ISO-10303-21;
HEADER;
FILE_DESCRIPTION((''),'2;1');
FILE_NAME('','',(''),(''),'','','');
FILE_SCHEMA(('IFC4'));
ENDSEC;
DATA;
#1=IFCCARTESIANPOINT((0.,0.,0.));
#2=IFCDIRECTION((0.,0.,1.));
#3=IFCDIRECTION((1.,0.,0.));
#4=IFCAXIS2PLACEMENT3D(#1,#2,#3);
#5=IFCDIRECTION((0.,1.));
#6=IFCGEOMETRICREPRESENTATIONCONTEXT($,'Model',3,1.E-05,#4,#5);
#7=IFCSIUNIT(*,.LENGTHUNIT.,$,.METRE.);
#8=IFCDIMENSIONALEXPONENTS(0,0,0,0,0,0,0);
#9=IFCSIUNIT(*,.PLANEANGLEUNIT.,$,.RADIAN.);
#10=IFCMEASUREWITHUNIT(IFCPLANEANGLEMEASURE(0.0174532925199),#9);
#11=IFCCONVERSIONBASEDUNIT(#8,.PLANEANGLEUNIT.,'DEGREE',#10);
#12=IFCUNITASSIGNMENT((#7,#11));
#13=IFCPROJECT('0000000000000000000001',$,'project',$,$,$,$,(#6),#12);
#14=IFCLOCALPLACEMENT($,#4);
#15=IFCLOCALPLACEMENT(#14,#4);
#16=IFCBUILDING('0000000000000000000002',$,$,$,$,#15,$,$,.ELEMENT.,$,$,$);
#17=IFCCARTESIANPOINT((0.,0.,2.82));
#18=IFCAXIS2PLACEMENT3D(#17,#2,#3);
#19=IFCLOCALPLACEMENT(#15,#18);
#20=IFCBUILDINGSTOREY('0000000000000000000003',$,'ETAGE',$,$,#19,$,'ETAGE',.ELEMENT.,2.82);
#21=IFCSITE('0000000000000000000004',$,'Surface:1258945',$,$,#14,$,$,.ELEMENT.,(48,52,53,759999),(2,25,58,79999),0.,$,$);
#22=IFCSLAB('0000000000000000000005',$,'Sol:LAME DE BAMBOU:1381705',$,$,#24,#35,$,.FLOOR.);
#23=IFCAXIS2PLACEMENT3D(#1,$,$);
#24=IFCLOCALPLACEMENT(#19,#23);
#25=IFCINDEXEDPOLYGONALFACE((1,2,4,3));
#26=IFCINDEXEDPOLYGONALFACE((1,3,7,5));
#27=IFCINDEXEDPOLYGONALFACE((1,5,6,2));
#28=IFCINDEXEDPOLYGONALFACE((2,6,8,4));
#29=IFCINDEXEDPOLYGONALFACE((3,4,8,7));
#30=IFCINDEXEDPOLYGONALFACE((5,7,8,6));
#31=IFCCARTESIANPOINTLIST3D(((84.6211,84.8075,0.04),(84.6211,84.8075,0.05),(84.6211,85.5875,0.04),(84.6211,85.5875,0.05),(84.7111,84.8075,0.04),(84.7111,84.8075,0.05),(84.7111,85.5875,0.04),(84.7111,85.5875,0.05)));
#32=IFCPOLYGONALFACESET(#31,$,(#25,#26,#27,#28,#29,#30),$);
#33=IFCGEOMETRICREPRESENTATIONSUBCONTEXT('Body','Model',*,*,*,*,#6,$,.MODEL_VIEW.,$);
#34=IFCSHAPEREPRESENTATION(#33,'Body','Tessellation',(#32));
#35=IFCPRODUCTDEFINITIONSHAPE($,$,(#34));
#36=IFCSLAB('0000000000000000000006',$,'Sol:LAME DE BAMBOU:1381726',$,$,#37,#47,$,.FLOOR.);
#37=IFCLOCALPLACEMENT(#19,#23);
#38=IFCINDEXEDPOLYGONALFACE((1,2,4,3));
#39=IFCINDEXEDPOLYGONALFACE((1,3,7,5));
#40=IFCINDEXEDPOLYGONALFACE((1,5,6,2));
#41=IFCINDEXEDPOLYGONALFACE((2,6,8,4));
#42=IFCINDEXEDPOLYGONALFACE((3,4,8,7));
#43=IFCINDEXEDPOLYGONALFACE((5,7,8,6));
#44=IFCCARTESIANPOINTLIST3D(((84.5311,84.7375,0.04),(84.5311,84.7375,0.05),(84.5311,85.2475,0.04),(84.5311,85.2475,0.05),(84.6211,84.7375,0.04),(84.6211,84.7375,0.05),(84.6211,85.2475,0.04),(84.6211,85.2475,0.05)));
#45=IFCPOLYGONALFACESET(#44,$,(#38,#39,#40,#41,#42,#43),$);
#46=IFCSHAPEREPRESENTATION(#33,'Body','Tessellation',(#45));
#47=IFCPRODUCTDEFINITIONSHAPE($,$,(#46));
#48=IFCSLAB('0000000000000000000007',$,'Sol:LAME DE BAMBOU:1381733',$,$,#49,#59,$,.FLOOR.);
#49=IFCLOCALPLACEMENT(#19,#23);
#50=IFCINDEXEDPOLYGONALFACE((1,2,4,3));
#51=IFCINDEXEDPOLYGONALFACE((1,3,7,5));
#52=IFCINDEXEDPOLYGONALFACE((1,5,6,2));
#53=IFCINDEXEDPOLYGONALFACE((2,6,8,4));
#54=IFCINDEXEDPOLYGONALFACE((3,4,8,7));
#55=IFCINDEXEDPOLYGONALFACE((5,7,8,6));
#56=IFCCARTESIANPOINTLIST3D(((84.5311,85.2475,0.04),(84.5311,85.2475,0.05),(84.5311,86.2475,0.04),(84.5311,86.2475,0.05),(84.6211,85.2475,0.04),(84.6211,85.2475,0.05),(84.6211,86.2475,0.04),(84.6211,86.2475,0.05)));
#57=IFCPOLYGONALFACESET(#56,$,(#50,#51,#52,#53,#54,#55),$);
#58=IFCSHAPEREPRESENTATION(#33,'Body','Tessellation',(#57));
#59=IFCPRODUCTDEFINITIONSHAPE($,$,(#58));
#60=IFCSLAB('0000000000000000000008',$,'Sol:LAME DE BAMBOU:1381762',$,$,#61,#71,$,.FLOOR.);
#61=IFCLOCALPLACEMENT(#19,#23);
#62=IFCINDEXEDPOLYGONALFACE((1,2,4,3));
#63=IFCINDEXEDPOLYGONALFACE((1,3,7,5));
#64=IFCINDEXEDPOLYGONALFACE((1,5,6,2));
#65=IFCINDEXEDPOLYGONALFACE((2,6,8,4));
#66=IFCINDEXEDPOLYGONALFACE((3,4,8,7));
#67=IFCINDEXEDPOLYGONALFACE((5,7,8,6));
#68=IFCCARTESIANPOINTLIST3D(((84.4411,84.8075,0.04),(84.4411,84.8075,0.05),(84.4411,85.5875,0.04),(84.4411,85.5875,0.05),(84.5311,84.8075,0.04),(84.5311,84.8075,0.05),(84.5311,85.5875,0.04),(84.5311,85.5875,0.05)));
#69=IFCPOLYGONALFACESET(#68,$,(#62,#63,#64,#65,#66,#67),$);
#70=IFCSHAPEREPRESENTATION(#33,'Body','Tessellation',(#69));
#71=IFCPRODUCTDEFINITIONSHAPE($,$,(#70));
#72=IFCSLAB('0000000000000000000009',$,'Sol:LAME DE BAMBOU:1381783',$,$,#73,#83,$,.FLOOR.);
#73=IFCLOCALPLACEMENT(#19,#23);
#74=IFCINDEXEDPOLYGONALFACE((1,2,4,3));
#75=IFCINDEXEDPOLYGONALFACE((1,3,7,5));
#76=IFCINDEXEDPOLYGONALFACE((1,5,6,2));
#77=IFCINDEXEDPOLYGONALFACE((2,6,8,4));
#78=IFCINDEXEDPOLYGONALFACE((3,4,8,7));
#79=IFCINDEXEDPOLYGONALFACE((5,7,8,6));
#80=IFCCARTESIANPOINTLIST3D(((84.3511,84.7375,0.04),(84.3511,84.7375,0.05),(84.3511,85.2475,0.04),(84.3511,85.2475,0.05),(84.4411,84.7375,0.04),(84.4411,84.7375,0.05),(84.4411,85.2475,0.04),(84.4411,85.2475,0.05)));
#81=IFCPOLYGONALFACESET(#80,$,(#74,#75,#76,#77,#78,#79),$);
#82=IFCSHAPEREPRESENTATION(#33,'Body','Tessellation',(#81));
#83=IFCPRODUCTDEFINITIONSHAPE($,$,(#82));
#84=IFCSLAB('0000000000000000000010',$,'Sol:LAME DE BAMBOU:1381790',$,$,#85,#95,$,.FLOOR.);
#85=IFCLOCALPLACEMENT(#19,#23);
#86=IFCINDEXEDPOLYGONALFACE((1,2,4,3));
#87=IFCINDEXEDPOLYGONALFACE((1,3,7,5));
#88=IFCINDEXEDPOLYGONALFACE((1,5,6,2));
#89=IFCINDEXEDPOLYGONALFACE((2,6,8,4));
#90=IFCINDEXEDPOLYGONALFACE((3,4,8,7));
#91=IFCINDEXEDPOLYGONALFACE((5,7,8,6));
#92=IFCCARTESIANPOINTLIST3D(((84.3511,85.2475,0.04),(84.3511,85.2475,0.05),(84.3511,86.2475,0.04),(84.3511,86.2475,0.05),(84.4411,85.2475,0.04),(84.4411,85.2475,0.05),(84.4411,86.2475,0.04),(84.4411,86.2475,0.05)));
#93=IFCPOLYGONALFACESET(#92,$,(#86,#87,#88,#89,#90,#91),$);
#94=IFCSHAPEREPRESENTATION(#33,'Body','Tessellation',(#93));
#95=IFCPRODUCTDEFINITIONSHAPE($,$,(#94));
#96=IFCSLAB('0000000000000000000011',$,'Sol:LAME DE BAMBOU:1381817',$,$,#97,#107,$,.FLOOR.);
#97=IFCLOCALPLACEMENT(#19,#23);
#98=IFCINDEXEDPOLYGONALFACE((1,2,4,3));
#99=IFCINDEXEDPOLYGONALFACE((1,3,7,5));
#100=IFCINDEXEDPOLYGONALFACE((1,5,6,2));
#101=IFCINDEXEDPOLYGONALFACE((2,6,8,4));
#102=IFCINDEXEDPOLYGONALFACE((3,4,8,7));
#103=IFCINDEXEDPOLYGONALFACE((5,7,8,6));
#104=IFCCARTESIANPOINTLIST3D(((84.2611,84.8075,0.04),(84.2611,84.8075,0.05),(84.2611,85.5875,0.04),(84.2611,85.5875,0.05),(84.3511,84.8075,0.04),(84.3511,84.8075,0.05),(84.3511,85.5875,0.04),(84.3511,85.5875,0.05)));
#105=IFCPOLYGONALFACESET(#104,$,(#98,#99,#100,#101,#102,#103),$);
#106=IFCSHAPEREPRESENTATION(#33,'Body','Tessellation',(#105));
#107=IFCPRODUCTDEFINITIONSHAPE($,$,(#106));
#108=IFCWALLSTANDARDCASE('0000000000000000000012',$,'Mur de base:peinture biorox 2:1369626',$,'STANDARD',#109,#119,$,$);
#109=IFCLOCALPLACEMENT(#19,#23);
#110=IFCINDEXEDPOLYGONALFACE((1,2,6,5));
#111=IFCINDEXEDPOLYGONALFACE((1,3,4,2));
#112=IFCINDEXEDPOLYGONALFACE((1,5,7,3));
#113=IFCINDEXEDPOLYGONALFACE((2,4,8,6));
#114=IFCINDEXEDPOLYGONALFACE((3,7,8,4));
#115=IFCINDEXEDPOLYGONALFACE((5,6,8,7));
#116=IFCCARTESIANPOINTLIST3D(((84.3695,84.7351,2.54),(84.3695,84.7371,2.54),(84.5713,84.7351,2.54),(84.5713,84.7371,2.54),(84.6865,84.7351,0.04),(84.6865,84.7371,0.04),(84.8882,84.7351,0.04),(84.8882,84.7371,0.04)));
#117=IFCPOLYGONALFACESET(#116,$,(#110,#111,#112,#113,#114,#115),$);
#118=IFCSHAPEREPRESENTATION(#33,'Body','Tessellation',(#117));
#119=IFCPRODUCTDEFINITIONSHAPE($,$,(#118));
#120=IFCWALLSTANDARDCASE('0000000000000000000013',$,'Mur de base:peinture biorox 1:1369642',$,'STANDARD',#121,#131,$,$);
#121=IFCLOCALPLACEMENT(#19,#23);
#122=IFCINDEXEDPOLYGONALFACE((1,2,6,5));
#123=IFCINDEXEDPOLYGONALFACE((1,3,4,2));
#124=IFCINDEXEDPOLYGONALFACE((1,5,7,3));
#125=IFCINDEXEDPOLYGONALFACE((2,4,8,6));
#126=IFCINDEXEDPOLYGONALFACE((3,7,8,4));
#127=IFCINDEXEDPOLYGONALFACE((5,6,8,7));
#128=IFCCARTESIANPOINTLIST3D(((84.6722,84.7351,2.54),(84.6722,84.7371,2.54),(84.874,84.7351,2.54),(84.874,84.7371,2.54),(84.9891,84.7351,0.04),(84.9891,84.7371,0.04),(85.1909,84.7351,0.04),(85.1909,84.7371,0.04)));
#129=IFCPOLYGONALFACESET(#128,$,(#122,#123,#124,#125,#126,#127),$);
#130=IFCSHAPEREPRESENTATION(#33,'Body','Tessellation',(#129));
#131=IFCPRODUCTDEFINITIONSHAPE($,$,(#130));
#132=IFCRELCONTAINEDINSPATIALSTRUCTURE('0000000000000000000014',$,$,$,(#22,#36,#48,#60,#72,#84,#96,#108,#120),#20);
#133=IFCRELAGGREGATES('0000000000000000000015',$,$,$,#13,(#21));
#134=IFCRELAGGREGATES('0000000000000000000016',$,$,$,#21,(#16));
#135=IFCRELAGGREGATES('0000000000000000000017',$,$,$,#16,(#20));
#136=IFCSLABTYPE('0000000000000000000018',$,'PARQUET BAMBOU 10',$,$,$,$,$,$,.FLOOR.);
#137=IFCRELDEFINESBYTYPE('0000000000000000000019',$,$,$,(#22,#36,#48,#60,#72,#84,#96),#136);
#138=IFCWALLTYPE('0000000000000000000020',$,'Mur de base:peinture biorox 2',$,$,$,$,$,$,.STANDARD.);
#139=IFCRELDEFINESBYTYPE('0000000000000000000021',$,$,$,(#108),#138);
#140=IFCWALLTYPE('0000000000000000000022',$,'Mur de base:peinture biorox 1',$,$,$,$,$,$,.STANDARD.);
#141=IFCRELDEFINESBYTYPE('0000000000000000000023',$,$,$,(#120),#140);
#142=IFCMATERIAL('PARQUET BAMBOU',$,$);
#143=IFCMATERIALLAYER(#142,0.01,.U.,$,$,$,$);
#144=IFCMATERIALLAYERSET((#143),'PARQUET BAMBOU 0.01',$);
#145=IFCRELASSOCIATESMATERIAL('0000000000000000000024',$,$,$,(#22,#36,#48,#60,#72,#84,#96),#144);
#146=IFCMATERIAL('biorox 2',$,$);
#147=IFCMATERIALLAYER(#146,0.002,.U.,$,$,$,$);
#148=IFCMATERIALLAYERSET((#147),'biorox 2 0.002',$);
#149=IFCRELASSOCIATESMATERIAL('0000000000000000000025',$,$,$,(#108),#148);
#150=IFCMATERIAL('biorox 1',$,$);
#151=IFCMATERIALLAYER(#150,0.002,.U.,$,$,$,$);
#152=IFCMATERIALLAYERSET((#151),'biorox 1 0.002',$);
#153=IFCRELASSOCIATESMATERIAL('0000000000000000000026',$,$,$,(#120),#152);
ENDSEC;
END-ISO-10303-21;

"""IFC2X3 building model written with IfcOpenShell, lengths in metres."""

from ifc_helpers import new_model, entity, si_unit, converted_unit, direction, frame, origin_with_axes, place, context, subcontext, project, spatial, polyline, outline, extrude, clip, halfspace, material, layer, layer_set, layer_usage, type_object, element, save


model = new_model("IFC2X3")

# Units and contexts
model_context = context("Model", 3, precision=1e-05, world=origin_with_axes(), true_north=direction((0.0, 1.0)))
body_context = subcontext(model_context, "Body", "Model", "MODEL_VIEW")
ifc_project = project(units=[si_unit("LENGTHUNIT", "METRE"), converted_unit("PLANEANGLEUNIT", "DEGREE", entity("IfcPlaneAngleMeasure", 0.0174532925199), si_unit("PLANEANGLEUNIT", "RADIAN"), dimensions=[0, 0, 0, 0, 0, 0, 0])], contexts=[model_context])

# Site, building, storey
site_placement = place(None, origin_with_axes())
site = spatial("IfcSite", under=ifc_project, at=site_placement, Name="Surface:1258945", CompositionType="ELEMENT", RefLatitude=(48, 52, 53, 759999), RefLongitude=(2, 25, 58, 79999), RefElevation=0.0)
building_placement = place(site_placement, origin_with_axes())
building = spatial("IfcBuilding", under=site, at=building_placement, CompositionType="ELEMENT")
storey_placement = place(building_placement, frame((0.0, 0.0, 2.82), z_axis=(0.0, 0.0, 1.0), x_axis=(1.0, 0.0, 0.0)))
storey = spatial("IfcBuildingStorey", under=building, at=storey_placement, Name="ETAGE", LongName="ETAGE", CompositionType="ELEMENT", Elevation=2.82)

# Slabs
ifc_material_1 = material(Name="PARQUET BAMBOU")
ifc_layer_1 = layer(ifc_material_1, 0.01, ventilated="UNKNOWN")
ifc_layer_set_1 = layer_set([ifc_layer_1], Name="PARQUET BAMBOU 0.01")
slab_type = type_object("IfcSlabType", Name="PARQUET BAMBOU 10", PredefinedType="FLOOR")
ifc_layer_usage_1 = layer_usage(ifc_layer_set_1, "AXIS3", "NEGATIVE", 0.01)
slab_1_placement = place(storey_placement, frame((84.6211, 85.5875, 0.05), z_axis=(0.0, 0.0, 1.0), x_axis=(1.0, 0.0, 0.0)))
element("IfcSlab", 1, at=slab_1_placement, inside=storey, type_object=slab_type, material=ifc_layer_usage_1, Name="Sol:LAME DE BAMBOU:1381705", PredefinedType="FLOOR", context=body_context, shape_type="SweptSolid", body=[
    extrude(outline(polyline([(0.0, 0.0), (0.0, -0.78), (0.09, -0.78), (0.09, 0.0), (0.0, 0.0)])), frame((0.0, 0.0, -0.01), z_axis=(0.0, 0.0, 1.0), x_axis=(1.0, 0.0, 0.0)), (0.0, 0.0, 1.0), 0.01),
])
ifc_layer_usage_2 = layer_usage(ifc_layer_set_1, "AXIS3", "NEGATIVE", 0.01)
slab_2_placement = place(storey_placement, frame((84.5311, 85.2475, 0.05), z_axis=(0.0, 0.0, 1.0), x_axis=(1.0, 0.0, 0.0)))
element("IfcSlab", 2, at=slab_2_placement, inside=storey, type_object=slab_type, material=ifc_layer_usage_2, Name="Sol:LAME DE BAMBOU:1381726", PredefinedType="FLOOR", context=body_context, shape_type="SweptSolid", body=[
    extrude(outline(polyline([(0.0, 0.0), (0.0, -0.51), (0.09, -0.51), (0.09, 0.0), (0.0, 0.0)])), frame((0.0, 0.0, -0.01), z_axis=(0.0, 0.0, 1.0), x_axis=(1.0, 0.0, 0.0)), (0.0, 0.0, 1.0), 0.01),
])
ifc_layer_usage_3 = layer_usage(ifc_layer_set_1, "AXIS3", "NEGATIVE", 0.01)
slab_3_placement = place(storey_placement, frame((84.5311, 86.2475, 0.05), z_axis=(0.0, 0.0, 1.0), x_axis=(1.0, 0.0, 0.0)))
element("IfcSlab", 3, at=slab_3_placement, inside=storey, type_object=slab_type, material=ifc_layer_usage_3, Name="Sol:LAME DE BAMBOU:1381733", PredefinedType="FLOOR", context=body_context, shape_type="SweptSolid", body=[
    extrude(outline(polyline([(0.0, 0.0), (0.0, -1.0), (0.09, -1.0), (0.09, 0.0), (0.0, 0.0)])), frame((0.0, 0.0, -0.01), z_axis=(0.0, 0.0, 1.0), x_axis=(1.0, 0.0, 0.0)), (0.0, 0.0, 1.0), 0.01),
])
ifc_layer_usage_4 = layer_usage(ifc_layer_set_1, "AXIS3", "NEGATIVE", 0.01)
slab_4_placement = place(storey_placement, frame((84.4411, 85.5875, 0.05), z_axis=(0.0, 0.0, 1.0), x_axis=(1.0, 0.0, 0.0)))
element("IfcSlab", 4, at=slab_4_placement, inside=storey, type_object=slab_type, material=ifc_layer_usage_4, Name="Sol:LAME DE BAMBOU:1381762", PredefinedType="FLOOR", context=body_context, shape_type="SweptSolid", body=[
    extrude(outline(polyline([(0.0, 0.0), (0.0, -0.78), (0.09, -0.78), (0.09, 0.0), (0.0, 0.0)])), frame((0.0, 0.0, -0.01), z_axis=(0.0, 0.0, 1.0), x_axis=(1.0, 0.0, 0.0)), (0.0, 0.0, 1.0), 0.01),
])
ifc_layer_usage_5 = layer_usage(ifc_layer_set_1, "AXIS3", "NEGATIVE", 0.01)
slab_5_placement = place(storey_placement, frame((84.3511, 85.2475, 0.05), z_axis=(0.0, 0.0, 1.0), x_axis=(1.0, 0.0, 0.0)))
element("IfcSlab", 5, at=slab_5_placement, inside=storey, type_object=slab_type, material=ifc_layer_usage_5, Name="Sol:LAME DE BAMBOU:1381783", PredefinedType="FLOOR", context=body_context, shape_type="SweptSolid", body=[
    extrude(outline(polyline([(0.0, 0.0), (0.0, -0.51), (0.09, -0.51), (0.09, 0.0), (0.0, 0.0)])), frame((0.0, 0.0, -0.01), z_axis=(0.0, 0.0, 1.0), x_axis=(1.0, 0.0, 0.0)), (0.0, 0.0, 1.0), 0.01),
])
ifc_layer_usage_6 = layer_usage(ifc_layer_set_1, "AXIS3", "NEGATIVE", 0.01)
slab_6_placement = place(storey_placement, frame((84.3511, 86.2475, 0.05), z_axis=(0.0, 0.0, 1.0), x_axis=(1.0, 0.0, 0.0)))
element("IfcSlab", 6, at=slab_6_placement, inside=storey, type_object=slab_type, material=ifc_layer_usage_6, Name="Sol:LAME DE BAMBOU:1381790", PredefinedType="FLOOR", context=body_context, shape_type="SweptSolid", body=[
    extrude(outline(polyline([(0.0, 0.0), (0.0, -1.0), (0.09, -1.0), (0.09, 0.0), (0.0, 0.0)])), frame((0.0, 0.0, -0.01), z_axis=(0.0, 0.0, 1.0), x_axis=(1.0, 0.0, 0.0)), (0.0, 0.0, 1.0), 0.01),
])
ifc_layer_usage_7 = layer_usage(ifc_layer_set_1, "AXIS3", "NEGATIVE", 0.01)
slab_7_placement = place(storey_placement, frame((84.2611, 85.5875, 0.05), z_axis=(0.0, 0.0, 1.0), x_axis=(1.0, 0.0, 0.0)))
element("IfcSlab", 7, at=slab_7_placement, inside=storey, type_object=slab_type, material=ifc_layer_usage_7, Name="Sol:LAME DE BAMBOU:1381817", PredefinedType="FLOOR", context=body_context, shape_type="SweptSolid", body=[
    extrude(outline(polyline([(0.0, 0.0), (0.0, -0.78), (0.09, -0.78), (0.09, 0.0), (0.0, 0.0)])), frame((0.0, 0.0, -0.01), z_axis=(0.0, 0.0, 1.0), x_axis=(1.0, 0.0, 0.0)), (0.0, 0.0, 1.0), 0.01),
])

# Walls
ifc_material_2 = material(Name="biorox 2")
ifc_layer_2 = layer(ifc_material_2, 0.002, ventilated="UNKNOWN")
ifc_layer_set_2 = layer_set([ifc_layer_2], Name="biorox 2 0.002")
ifc_layer_usage_8 = layer_usage(ifc_layer_set_2, "AXIS2", "POSITIVE", -0.001)
wall_type_1 = type_object("IfcWallType", Name="Mur de base:peinture biorox 2", PredefinedType="STANDARD")
wall_1_placement = place(storey_placement, frame((84.3695, 84.7361, 0.04), z_axis=(0.0, 0.0, 1.0), x_axis=(1.0, 0.0, 0.0)))
element("IfcWallStandardCase", 8, at=wall_1_placement, inside=storey, type_object=wall_type_1, material=ifc_layer_usage_8, Name="Mur de base:peinture biorox 2:1369626", ObjectType="STANDARD", context=body_context, shape_type="Clipping", body=[
    clip(clip(extrude(outline(polyline([(0.0, -0.001), (0.5187, -0.001), (0.5187, 0.001), (0.0, 0.001), (0.0, -0.001)])), origin_with_axes(), (0.0, 0.0, 1.0), 2.5), halfspace(frame((0.5105, 0.0, 0.0647), z_axis=(-0.99206, 0.0, -0.125765), x_axis=(0.0, 1.0, 0.0)), True)), halfspace(frame((0.3119, 0.0, 0.0395), z_axis=(0.99206, 0.0, 0.125765), x_axis=(0.0, -1.0, 0.0)), True)),
])
ifc_material_3 = material(Name="biorox 1")
ifc_layer_3 = layer(ifc_material_3, 0.002, ventilated="UNKNOWN")
ifc_layer_set_3 = layer_set([ifc_layer_3], Name="biorox 1 0.002")
ifc_layer_usage_9 = layer_usage(ifc_layer_set_3, "AXIS2", "POSITIVE", -0.001)
wall_type_2 = type_object("IfcWallType", Name="Mur de base:peinture biorox 1", PredefinedType="STANDARD")
wall_2_placement = place(storey_placement, frame((84.6722, 84.7361, 0.04), z_axis=(0.0, 0.0, 1.0), x_axis=(1.0, 0.0, 0.0)))
element("IfcWallStandardCase", 9, at=wall_2_placement, inside=storey, type_object=wall_type_2, material=ifc_layer_usage_9, Name="Mur de base:peinture biorox 1:1369642", ObjectType="STANDARD", context=body_context, shape_type="Clipping", body=[
    clip(clip(extrude(outline(polyline([(0.0, -0.001), (0.5187, -0.001), (0.5187, 0.001), (0.0, 0.001), (0.0, -0.001)])), origin_with_axes(), (0.0, 0.0, 1.0), 2.5), halfspace(frame((0.5105, 0.0, 0.0647), z_axis=(-0.99206, 0.0, -0.125765), x_axis=(0.0, 1.0, 0.0)), True)), halfspace(frame((0.3119, 0.0, 0.0395), z_axis=(0.99206, 0.0, 0.125765), x_axis=(0.0, -1.0, 0.0)), True)),
])

save(model, "model.ifc")
